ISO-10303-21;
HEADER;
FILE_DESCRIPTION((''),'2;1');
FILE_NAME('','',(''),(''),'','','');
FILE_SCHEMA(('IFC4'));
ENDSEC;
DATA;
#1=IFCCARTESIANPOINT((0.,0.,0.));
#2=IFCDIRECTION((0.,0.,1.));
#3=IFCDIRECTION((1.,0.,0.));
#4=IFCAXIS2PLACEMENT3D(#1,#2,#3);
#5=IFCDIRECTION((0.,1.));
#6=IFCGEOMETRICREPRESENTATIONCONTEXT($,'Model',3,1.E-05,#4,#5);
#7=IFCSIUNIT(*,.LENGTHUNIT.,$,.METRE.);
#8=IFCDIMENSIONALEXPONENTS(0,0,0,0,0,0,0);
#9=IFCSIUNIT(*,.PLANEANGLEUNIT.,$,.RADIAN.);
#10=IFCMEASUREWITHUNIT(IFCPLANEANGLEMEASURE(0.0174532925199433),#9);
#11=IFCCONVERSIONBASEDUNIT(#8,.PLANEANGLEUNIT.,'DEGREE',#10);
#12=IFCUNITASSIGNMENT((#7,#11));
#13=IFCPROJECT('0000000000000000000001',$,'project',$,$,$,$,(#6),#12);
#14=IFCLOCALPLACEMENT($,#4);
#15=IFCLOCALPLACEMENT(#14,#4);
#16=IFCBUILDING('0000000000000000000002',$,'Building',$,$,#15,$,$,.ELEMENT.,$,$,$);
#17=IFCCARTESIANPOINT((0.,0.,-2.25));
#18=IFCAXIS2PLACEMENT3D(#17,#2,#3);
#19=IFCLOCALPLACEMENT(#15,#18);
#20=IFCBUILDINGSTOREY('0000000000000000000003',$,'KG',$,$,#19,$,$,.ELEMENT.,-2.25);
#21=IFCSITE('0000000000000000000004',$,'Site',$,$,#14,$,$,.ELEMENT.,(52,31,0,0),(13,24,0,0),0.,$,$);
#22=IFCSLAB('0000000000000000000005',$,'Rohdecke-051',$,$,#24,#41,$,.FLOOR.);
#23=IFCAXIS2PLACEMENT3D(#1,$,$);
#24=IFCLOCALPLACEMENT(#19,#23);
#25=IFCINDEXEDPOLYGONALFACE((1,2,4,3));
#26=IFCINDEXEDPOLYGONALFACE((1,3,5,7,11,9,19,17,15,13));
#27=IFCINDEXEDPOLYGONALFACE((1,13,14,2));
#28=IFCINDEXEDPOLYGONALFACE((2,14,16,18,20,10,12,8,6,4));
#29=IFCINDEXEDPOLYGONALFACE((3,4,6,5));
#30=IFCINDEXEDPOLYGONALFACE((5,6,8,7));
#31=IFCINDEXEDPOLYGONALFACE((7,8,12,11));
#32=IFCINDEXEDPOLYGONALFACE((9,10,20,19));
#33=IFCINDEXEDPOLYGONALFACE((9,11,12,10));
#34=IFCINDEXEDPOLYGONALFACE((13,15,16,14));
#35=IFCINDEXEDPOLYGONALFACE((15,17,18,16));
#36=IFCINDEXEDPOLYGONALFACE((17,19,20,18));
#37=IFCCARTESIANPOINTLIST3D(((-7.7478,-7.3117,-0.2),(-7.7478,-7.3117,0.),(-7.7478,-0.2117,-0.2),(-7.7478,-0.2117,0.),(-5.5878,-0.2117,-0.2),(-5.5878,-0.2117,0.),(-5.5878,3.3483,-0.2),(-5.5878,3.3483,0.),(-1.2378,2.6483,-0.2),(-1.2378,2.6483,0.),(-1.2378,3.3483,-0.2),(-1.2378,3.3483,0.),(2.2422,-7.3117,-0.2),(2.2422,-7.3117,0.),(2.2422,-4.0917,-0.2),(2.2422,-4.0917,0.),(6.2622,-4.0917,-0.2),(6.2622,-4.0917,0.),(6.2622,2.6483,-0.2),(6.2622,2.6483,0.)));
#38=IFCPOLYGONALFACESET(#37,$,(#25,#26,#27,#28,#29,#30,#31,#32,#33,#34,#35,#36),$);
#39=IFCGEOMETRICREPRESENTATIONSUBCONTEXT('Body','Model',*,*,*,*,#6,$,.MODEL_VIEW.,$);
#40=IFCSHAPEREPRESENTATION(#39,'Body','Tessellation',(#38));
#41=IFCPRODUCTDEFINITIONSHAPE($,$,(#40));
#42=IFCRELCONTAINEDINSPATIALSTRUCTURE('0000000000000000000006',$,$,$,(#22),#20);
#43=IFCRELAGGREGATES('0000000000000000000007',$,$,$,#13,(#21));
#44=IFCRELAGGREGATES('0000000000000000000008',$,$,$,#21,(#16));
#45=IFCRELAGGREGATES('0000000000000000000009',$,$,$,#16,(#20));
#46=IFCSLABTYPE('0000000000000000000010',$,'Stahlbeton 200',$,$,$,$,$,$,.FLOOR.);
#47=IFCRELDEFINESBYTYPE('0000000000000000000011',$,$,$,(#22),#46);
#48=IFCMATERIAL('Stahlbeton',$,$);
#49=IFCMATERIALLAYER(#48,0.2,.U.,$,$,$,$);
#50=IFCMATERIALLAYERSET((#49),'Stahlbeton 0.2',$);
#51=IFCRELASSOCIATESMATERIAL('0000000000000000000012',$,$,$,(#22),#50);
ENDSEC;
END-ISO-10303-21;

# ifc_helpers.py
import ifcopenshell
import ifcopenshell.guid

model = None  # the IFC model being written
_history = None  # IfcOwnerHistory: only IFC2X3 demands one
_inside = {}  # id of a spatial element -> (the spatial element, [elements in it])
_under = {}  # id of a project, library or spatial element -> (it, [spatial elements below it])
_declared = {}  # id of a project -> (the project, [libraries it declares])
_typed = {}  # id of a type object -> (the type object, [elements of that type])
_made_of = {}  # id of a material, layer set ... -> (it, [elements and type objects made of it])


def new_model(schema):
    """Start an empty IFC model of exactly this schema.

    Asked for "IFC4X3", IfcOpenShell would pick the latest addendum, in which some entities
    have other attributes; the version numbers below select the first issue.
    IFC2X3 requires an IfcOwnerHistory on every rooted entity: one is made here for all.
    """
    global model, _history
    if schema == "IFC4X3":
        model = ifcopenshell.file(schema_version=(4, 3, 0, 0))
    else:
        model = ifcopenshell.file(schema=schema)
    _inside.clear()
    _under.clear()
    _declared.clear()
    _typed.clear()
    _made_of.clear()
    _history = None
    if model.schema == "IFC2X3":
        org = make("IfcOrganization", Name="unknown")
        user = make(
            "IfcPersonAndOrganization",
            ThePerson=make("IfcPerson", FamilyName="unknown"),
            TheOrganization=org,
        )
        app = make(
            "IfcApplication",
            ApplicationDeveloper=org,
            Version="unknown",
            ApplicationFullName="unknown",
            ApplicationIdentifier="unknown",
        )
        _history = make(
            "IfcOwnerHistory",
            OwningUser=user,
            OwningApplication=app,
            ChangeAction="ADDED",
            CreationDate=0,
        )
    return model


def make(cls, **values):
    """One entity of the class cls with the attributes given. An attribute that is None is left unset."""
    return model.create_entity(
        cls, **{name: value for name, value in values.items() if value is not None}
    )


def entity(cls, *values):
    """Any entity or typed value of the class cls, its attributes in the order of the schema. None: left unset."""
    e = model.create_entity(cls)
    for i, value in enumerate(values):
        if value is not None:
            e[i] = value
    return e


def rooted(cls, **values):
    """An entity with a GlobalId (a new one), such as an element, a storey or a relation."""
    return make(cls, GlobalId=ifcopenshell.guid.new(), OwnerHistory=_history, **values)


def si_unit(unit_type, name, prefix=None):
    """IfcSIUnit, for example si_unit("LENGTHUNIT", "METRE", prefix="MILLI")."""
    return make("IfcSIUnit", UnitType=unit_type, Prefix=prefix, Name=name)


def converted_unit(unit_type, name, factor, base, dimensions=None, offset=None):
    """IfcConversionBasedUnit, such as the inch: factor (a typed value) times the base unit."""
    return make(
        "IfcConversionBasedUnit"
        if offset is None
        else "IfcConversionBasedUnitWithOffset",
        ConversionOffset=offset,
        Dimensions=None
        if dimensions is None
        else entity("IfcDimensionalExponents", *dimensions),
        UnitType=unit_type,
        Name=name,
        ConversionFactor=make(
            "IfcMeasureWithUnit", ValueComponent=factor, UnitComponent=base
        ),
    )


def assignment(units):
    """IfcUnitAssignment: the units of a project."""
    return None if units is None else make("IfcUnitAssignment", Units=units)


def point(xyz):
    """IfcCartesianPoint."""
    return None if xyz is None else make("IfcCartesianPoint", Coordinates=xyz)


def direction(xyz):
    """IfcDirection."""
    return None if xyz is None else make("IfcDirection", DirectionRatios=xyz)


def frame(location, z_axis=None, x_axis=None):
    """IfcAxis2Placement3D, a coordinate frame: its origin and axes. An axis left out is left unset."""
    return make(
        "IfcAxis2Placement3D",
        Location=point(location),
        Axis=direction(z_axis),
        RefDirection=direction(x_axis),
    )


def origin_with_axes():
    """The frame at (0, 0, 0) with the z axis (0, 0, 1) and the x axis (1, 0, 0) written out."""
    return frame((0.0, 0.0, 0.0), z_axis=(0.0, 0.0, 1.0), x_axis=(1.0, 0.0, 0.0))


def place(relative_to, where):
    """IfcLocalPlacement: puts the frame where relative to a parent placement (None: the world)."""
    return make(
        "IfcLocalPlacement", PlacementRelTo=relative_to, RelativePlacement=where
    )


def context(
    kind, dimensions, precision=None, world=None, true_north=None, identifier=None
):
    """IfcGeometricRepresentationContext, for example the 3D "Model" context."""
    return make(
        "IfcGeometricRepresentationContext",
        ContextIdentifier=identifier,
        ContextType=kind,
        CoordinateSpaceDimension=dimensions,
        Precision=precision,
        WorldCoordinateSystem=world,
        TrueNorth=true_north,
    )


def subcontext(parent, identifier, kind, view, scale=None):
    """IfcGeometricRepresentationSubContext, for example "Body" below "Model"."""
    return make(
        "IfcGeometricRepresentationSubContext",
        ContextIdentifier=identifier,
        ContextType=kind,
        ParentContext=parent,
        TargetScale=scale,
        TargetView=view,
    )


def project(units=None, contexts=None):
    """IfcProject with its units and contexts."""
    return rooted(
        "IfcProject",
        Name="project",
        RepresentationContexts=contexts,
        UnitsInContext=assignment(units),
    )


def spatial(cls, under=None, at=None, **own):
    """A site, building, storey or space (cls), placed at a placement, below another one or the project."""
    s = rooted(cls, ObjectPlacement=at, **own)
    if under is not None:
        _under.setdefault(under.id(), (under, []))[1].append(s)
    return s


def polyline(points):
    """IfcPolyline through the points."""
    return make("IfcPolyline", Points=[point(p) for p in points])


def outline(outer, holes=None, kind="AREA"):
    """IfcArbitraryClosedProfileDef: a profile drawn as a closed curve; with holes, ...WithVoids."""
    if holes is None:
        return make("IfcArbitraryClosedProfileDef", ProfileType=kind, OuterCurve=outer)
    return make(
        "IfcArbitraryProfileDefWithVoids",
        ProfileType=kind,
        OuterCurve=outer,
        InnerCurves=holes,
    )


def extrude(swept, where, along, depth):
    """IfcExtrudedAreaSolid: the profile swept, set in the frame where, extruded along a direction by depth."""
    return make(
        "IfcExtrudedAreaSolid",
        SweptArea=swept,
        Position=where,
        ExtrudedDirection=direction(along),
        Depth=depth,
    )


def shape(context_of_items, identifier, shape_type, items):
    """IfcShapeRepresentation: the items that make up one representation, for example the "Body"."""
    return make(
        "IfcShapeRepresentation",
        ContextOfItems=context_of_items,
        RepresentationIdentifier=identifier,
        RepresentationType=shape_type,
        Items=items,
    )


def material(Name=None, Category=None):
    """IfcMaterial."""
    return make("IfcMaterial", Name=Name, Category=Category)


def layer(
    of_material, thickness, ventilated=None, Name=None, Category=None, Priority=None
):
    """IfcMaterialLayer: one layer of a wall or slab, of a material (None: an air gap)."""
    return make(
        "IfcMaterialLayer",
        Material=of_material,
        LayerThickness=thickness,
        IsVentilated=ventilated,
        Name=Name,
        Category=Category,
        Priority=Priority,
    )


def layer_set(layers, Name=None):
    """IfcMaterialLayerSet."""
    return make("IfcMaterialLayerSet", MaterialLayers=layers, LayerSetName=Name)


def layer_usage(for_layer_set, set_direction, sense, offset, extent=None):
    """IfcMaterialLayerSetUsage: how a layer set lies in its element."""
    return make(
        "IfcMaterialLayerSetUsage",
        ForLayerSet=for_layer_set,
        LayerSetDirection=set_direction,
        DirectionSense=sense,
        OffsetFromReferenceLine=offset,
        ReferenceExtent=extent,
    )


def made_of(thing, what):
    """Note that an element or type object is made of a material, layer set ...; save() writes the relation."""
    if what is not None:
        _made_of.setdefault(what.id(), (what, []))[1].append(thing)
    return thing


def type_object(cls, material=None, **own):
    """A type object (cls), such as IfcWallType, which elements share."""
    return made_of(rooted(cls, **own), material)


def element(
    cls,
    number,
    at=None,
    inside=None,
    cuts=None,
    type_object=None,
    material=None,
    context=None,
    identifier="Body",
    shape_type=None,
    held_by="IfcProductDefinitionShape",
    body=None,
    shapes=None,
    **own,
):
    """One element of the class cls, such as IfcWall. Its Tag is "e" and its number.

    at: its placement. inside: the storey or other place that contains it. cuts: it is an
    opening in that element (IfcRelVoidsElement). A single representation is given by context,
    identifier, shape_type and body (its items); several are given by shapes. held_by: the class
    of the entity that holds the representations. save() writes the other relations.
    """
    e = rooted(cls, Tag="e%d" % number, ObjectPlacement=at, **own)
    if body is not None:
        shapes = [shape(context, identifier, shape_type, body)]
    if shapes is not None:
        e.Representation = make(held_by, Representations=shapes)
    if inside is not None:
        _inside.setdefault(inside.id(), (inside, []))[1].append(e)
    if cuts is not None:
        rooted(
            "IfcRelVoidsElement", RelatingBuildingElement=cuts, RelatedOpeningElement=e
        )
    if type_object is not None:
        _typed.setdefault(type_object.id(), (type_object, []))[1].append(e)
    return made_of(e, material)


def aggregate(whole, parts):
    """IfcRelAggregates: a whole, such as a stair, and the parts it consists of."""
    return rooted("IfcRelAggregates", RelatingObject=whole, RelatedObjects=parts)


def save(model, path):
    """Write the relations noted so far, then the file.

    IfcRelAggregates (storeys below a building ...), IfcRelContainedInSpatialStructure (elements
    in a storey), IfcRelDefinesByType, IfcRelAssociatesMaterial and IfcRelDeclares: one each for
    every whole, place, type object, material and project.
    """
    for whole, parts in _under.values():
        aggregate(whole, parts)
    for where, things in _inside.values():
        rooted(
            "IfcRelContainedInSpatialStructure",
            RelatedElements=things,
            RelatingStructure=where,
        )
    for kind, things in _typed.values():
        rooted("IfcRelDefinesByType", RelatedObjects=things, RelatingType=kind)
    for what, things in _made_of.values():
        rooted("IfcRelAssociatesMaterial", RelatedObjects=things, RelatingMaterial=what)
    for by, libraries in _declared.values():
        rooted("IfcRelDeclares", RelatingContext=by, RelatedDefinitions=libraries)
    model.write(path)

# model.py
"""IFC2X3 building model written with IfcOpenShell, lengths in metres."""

from ifc_helpers import new_model, entity, si_unit, converted_unit, direction, frame, origin_with_axes, place, context, subcontext, project, spatial, polyline, outline, extrude, material, layer, layer_set, layer_usage, type_object, element, save


model = new_model("IFC2X3")

# Units and contexts
model_context = context("Model", 3, precision=1e-05, world=origin_with_axes(), true_north=direction((0.0, 1.0)))
body_context = subcontext(model_context, "Body", "Model", "MODEL_VIEW")
ifc_project = project(units=[si_unit("LENGTHUNIT", "METRE"), converted_unit("PLANEANGLEUNIT", "DEGREE", entity("IfcPlaneAngleMeasure", 0.0174532925199433), si_unit("PLANEANGLEUNIT", "RADIAN"), dimensions=[0, 0, 0, 0, 0, 0, 0])], contexts=[model_context])

# Site, building, storey
site_placement = place(None, origin_with_axes())
site = spatial("IfcSite", under=ifc_project, at=site_placement, Name="Site", CompositionType="ELEMENT", RefLatitude=(52, 31, 0, 0), RefLongitude=(13, 24, 0, 0), RefElevation=0.0)
building_placement = place(site_placement, origin_with_axes())
building = spatial("IfcBuilding", under=site, at=building_placement, Name="Building", CompositionType="ELEMENT")
storey_placement = place(building_placement, frame((0.0, 0.0, -2.25), z_axis=(0.0, 0.0, 1.0), x_axis=(1.0, 0.0, 0.0)))
storey = spatial("IfcBuildingStorey", under=building, at=storey_placement, Name="KG", CompositionType="ELEMENT", Elevation=-2.25)

# Slab
ifc_material = material(Name="Stahlbeton")
ifc_layer = layer(ifc_material, 0.2, ventilated="UNKNOWN")
ifc_layer_set = layer_set([ifc_layer], Name="Stahlbeton 0.2")
ifc_layer_usage = layer_usage(ifc_layer_set, "AXIS3", "NEGATIVE", 0.2)
slab_type = type_object("IfcSlabType", Name="Stahlbeton 200", PredefinedType="FLOOR")
slab_placement = place(storey_placement, frame((-7.7478, -7.3117, 0.0), z_axis=(0.0, 0.0, 1.0), x_axis=(1.0, 0.0, 0.0)))
element("IfcSlab", 1, at=slab_placement, inside=storey, type_object=slab_type, material=ifc_layer_usage, Name="Rohdecke-051", PredefinedType="FLOOR", context=body_context, shape_type="SweptSolid", body=[
    extrude(outline(polyline([(0.0, 0.0), (9.99, 0.0), (9.99, 3.22), (14.01, 3.22), (14.01, 9.96), (6.51, 9.96), (6.51, 10.66), (2.16, 10.66), (2.16, 7.1), (0.0, 7.1), (0.0, 0.0)])), frame((0.0, 0.0, -0.2), z_axis=(0.0, 0.0, 1.0), x_axis=(1.0, 0.0, 0.0)), (0.0, 0.0, 1.0), 0.2),
])

save(model, "model.ifc")
